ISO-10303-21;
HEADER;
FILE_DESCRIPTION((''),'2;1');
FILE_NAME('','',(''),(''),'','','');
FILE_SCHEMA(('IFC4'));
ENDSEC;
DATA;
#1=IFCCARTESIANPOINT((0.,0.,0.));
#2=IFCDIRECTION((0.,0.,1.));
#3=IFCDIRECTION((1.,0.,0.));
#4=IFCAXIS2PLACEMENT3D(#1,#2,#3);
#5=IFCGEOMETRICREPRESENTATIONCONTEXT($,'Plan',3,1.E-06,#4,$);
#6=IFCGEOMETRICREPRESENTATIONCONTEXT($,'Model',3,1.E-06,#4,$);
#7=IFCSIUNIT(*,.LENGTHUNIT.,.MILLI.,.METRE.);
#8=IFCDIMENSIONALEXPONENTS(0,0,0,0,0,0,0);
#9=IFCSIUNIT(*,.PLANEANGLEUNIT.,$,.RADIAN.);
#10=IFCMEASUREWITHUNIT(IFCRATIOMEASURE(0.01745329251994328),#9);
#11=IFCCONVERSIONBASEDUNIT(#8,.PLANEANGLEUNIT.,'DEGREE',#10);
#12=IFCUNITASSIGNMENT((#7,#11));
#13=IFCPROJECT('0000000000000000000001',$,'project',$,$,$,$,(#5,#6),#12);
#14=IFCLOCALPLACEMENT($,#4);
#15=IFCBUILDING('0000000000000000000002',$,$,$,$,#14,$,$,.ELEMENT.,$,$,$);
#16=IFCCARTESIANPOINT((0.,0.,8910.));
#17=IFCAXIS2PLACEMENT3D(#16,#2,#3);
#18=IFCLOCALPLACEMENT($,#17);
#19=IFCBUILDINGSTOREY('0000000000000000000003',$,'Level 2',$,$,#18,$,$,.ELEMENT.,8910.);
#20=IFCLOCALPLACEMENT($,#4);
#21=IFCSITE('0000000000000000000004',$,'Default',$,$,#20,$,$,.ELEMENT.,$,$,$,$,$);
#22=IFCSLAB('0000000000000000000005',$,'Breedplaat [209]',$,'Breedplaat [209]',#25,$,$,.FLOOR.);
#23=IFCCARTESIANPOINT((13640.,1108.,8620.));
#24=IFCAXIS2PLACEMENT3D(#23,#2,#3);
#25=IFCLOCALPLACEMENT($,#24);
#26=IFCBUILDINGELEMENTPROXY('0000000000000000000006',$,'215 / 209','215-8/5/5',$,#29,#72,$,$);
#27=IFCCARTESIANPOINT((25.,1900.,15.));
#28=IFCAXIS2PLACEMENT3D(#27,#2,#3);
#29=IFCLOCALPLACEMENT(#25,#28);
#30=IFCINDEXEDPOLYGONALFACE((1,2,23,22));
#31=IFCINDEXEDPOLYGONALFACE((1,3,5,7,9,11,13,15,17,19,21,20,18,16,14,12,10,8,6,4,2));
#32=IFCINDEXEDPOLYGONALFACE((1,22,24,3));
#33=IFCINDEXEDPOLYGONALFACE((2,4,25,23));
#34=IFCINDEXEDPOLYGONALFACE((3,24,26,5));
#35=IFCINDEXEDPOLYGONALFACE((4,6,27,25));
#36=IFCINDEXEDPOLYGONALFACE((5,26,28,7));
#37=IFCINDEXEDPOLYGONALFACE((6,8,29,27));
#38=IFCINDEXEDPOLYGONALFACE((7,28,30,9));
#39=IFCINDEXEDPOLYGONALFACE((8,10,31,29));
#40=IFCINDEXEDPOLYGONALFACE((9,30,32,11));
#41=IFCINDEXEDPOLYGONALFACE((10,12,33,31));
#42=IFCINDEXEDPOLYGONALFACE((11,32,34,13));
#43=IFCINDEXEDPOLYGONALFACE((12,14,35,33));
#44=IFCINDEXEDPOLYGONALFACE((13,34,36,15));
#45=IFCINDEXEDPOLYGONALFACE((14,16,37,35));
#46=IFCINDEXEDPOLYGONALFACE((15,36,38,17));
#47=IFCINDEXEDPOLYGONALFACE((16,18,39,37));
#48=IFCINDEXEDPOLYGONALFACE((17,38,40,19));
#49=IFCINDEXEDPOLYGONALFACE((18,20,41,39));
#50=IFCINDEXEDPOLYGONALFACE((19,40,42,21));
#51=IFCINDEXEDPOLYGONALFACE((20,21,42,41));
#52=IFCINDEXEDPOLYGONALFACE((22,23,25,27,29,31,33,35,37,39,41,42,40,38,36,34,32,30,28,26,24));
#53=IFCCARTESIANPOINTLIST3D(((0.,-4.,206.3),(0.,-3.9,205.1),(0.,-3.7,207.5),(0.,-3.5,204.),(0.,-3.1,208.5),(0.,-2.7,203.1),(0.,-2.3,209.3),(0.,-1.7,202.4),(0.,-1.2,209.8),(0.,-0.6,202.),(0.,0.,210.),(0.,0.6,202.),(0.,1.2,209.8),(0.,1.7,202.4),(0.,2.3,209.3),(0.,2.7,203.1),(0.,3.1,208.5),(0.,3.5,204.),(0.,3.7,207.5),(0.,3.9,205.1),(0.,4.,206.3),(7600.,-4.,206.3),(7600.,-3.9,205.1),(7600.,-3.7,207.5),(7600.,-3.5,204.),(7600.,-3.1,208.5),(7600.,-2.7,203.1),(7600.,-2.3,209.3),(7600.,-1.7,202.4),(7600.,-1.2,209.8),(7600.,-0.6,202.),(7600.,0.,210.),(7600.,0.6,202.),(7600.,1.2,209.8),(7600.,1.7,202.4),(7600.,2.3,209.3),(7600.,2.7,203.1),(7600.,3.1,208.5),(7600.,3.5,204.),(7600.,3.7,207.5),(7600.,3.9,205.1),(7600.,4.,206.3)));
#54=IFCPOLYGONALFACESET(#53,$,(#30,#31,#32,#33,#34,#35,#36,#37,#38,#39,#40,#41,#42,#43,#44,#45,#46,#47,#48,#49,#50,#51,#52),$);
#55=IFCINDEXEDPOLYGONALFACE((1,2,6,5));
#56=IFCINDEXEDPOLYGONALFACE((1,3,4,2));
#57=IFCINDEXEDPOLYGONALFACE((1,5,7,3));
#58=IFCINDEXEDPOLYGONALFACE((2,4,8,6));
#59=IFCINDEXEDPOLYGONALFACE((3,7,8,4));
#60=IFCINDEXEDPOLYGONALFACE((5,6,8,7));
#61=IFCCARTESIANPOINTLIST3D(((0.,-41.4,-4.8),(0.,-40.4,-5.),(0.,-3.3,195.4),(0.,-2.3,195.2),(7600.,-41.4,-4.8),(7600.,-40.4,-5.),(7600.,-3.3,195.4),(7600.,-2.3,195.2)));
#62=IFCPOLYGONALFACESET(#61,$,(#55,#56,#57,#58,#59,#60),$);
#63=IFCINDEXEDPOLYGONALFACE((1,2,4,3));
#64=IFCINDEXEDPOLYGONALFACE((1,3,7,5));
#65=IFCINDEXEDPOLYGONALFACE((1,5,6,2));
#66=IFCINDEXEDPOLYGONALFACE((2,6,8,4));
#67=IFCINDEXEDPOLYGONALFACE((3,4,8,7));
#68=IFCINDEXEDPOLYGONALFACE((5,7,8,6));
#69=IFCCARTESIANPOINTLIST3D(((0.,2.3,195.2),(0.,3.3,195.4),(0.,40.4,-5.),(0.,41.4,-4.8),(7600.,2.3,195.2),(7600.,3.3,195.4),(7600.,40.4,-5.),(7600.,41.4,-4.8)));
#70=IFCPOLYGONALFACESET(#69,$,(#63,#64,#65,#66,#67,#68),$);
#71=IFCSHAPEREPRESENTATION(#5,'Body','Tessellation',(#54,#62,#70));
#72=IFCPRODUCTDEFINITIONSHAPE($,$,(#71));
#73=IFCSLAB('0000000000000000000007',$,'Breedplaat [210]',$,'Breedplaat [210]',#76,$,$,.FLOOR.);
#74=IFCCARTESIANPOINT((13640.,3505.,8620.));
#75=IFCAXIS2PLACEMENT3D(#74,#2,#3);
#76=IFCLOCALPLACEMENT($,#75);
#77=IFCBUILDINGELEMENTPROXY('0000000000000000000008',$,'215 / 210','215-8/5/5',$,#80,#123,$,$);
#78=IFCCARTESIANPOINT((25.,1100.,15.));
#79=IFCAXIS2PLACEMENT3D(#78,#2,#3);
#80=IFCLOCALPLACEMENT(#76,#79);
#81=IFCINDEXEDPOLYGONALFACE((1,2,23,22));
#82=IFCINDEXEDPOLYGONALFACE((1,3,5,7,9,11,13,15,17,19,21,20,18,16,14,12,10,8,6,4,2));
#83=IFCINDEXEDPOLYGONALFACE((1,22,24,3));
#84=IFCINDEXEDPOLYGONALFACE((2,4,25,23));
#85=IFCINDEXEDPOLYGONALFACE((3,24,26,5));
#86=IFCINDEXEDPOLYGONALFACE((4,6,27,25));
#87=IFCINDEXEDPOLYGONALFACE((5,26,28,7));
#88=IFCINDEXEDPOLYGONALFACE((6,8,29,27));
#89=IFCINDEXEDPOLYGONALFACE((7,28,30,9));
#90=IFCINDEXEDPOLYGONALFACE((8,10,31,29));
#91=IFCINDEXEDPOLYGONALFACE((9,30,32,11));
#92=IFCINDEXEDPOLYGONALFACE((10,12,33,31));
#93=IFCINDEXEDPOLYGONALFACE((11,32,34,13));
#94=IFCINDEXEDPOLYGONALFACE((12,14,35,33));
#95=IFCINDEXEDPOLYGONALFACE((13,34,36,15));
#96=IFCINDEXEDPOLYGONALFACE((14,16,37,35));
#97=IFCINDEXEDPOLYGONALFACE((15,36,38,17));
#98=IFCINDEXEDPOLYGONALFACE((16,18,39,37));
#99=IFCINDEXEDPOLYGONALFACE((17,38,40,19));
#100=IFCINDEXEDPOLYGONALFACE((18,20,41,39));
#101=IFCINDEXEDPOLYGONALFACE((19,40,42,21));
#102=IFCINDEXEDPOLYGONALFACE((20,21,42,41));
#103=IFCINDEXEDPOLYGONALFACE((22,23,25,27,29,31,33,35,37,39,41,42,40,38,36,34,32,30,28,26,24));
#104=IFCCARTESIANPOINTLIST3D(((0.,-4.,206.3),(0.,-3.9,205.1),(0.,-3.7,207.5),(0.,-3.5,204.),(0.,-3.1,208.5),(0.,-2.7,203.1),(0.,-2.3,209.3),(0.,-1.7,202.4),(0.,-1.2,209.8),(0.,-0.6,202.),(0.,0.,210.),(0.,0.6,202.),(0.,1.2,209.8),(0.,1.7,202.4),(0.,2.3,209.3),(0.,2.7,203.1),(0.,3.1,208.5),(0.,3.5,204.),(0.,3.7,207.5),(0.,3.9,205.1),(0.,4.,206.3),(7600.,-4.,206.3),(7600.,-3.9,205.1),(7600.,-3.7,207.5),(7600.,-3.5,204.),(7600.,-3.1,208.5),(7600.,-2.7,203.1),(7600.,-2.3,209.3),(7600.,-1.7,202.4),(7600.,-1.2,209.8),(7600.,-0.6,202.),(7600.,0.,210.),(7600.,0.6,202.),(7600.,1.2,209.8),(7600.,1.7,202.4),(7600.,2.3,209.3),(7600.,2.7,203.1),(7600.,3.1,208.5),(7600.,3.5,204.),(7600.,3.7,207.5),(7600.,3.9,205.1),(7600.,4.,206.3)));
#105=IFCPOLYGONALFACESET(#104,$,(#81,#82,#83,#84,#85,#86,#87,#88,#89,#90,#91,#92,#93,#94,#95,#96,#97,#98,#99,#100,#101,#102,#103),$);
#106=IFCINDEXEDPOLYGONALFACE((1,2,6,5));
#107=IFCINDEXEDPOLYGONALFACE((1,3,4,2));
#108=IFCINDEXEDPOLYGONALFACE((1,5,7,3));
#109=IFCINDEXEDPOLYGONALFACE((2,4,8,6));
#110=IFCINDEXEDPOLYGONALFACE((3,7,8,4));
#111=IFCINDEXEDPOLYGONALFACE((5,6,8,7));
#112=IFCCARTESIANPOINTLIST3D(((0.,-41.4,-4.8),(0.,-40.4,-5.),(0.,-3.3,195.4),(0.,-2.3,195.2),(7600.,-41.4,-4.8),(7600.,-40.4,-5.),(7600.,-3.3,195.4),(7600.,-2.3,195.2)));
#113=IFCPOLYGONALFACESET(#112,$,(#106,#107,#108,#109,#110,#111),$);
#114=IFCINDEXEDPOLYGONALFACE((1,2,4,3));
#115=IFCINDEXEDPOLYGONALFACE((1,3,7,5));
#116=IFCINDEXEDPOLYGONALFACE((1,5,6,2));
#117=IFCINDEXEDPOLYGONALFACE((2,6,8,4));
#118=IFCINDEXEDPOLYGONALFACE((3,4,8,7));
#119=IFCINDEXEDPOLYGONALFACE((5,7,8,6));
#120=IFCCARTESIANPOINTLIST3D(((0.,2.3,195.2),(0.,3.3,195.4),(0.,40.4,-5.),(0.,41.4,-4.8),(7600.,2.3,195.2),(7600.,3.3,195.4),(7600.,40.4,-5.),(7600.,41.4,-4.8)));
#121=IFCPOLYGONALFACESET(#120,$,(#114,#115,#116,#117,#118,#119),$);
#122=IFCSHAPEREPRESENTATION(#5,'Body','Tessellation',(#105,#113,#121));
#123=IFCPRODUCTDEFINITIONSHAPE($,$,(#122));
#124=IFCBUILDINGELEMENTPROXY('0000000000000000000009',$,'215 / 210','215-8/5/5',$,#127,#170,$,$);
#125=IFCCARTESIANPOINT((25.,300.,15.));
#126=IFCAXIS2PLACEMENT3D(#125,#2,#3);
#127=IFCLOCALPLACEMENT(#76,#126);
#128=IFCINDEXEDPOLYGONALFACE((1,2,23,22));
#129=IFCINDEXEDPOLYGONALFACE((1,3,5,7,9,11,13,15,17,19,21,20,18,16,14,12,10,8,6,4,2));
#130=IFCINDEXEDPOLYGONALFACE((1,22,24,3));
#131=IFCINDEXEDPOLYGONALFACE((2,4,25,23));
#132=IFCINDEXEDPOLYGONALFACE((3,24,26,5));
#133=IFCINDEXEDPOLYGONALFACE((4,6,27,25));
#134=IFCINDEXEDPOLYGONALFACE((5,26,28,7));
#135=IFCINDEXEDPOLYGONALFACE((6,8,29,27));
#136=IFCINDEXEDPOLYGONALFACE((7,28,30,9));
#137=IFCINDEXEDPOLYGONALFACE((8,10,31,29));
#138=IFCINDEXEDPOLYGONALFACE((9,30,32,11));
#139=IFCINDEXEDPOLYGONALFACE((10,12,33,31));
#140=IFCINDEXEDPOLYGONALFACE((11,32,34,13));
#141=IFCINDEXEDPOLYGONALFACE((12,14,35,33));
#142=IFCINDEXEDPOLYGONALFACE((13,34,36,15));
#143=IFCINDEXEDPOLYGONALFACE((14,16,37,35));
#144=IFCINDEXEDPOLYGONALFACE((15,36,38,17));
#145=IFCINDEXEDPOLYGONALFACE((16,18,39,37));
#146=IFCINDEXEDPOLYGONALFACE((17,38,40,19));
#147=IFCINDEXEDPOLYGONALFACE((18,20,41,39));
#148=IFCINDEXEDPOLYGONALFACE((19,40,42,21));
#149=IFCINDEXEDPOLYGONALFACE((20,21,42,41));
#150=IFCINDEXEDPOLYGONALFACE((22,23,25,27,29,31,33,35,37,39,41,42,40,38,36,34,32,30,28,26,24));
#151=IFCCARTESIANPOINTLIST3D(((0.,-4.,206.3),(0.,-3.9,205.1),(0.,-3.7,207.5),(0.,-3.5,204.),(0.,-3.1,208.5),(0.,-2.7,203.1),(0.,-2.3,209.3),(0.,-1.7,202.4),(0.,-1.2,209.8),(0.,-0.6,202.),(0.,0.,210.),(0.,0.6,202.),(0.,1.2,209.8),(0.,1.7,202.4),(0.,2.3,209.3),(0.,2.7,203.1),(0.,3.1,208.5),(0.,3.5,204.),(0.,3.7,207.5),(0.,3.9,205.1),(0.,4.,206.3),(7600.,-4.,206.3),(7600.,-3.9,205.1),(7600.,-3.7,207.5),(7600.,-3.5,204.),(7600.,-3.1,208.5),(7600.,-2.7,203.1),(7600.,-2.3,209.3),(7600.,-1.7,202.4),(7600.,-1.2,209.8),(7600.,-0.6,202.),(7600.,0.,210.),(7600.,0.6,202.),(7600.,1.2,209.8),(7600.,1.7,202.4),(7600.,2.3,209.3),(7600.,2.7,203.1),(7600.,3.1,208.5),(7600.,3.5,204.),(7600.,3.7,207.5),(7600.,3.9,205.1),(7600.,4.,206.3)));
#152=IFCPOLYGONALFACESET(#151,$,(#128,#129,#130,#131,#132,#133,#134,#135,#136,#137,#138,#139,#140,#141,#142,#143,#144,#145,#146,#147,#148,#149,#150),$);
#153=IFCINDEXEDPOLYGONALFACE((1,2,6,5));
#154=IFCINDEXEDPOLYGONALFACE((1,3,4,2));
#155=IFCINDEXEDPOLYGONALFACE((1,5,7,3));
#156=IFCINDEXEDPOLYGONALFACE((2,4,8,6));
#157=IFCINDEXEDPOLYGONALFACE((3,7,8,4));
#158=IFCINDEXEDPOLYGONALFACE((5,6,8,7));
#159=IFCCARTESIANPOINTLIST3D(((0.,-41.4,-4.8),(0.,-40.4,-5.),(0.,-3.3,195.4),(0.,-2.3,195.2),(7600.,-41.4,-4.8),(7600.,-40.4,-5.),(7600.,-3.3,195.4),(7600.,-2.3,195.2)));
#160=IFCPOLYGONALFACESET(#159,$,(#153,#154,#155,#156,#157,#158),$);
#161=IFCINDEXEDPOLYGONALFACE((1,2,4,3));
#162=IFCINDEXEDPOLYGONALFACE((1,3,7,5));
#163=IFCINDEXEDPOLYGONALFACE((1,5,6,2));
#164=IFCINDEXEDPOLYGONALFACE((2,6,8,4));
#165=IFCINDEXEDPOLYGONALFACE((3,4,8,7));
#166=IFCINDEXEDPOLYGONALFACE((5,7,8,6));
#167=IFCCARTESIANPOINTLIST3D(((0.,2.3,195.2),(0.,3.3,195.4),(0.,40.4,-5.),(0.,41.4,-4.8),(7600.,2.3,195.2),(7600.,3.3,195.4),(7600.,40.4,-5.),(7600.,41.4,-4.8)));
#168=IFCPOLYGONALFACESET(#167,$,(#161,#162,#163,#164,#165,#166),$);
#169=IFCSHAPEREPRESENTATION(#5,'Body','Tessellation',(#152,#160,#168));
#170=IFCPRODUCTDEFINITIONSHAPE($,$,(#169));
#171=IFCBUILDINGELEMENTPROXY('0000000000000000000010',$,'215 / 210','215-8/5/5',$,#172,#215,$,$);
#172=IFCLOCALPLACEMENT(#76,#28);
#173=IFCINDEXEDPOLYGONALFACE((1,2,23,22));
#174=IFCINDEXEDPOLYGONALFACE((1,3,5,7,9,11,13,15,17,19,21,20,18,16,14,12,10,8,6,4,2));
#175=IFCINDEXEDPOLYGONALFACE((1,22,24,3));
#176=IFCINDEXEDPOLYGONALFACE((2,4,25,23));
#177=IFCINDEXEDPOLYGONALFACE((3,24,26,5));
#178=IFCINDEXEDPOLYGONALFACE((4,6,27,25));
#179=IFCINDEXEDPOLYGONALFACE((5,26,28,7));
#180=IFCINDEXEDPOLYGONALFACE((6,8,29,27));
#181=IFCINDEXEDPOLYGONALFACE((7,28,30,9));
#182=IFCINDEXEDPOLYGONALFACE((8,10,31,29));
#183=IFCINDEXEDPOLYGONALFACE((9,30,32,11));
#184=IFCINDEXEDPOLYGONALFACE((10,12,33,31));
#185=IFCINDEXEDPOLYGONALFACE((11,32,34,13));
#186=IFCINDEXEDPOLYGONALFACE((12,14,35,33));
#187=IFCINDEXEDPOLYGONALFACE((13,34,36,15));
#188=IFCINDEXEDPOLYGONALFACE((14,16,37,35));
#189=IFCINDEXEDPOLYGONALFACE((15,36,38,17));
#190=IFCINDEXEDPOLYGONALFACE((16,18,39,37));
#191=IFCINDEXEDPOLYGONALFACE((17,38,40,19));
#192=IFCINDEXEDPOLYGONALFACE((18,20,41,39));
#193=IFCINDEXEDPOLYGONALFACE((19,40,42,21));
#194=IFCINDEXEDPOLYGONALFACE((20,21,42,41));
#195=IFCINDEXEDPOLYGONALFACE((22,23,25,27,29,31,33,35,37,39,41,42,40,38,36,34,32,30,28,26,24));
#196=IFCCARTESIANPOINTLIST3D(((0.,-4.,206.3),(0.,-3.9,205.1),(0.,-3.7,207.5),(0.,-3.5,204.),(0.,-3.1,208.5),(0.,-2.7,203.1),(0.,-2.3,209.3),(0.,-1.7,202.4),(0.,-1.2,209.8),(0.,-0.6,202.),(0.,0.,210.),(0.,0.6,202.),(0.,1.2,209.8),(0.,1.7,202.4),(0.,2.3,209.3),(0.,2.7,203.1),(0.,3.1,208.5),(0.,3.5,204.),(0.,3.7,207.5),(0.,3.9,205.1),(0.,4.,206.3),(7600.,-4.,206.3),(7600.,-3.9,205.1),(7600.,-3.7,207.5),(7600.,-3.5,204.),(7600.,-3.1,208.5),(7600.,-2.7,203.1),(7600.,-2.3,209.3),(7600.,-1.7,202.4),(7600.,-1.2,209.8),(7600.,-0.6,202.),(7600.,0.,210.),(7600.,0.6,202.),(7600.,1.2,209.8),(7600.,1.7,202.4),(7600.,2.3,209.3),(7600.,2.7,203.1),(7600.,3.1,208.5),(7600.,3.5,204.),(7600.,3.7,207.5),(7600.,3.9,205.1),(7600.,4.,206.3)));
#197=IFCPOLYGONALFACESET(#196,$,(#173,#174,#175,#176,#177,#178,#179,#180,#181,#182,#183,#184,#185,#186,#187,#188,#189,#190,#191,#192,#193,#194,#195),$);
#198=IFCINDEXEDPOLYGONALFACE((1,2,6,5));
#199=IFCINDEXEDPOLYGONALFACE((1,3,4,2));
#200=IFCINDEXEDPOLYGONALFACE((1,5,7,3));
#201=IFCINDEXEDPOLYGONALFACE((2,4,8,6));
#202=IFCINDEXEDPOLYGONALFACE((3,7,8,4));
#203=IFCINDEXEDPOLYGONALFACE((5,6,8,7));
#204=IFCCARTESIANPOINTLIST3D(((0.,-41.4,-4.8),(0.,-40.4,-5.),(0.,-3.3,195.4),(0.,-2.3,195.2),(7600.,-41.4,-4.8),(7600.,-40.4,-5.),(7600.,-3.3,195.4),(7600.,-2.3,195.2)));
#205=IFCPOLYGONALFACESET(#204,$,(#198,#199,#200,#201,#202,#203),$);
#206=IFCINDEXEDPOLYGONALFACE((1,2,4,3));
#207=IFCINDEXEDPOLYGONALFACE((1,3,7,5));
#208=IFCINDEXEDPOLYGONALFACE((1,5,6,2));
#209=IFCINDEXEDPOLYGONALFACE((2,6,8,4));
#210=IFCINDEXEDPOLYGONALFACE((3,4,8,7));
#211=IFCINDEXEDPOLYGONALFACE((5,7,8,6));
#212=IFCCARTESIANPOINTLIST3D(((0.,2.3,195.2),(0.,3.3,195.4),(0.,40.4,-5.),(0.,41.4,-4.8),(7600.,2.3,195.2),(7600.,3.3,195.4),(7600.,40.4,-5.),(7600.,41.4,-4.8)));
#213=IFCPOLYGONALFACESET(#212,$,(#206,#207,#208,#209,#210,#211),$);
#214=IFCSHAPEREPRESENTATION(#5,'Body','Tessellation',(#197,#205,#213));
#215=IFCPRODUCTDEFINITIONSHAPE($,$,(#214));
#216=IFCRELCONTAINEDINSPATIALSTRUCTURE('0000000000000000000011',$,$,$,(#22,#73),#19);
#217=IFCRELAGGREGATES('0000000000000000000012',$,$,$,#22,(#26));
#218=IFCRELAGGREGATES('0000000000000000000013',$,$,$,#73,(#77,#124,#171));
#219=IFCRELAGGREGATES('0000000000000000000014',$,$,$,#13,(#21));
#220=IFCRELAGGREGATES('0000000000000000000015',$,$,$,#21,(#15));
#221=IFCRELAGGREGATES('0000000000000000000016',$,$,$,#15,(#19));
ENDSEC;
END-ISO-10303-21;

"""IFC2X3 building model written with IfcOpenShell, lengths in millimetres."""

from ifc_helpers import new_model, entity, si_unit, converted_unit, frame, origin_with_axes, origin_2d_with_axis, place, context, project, spatial, rectangle, circle, extrude, element, aggregate, save


model = new_model("IFC2X3")

# Units and contexts
plan_context = context("Plan", 3, precision=1e-06, world=origin_with_axes())
model_context = context("Model", 3, precision=1e-06, world=origin_with_axes())
ifc_project = project(units=[si_unit("LENGTHUNIT", "METRE", prefix="MILLI"), converted_unit("PLANEANGLEUNIT", "DEGREE", entity("IfcRatioMeasure", 0.01745329251994328), si_unit("PLANEANGLEUNIT", "RADIAN"), dimensions=[0, 0, 0, 0, 0, 0, 0])], contexts=[plan_context, model_context])

# Site, building, storey
site_placement = place(None, origin_with_axes())
site = spatial("IfcSite", under=ifc_project, at=site_placement, Name="Default", CompositionType="ELEMENT")
building_placement = place(None, origin_with_axes())
building = spatial("IfcBuilding", under=site, at=building_placement, CompositionType="ELEMENT")
storey_placement = place(None, frame((0.0, 0.0, 8910.0), z_axis=(0.0, 0.0, 1.0), x_axis=(1.0, 0.0, 0.0)))
storey = spatial("IfcBuildingStorey", under=building, at=storey_placement, Name="Level 2", CompositionType="ELEMENT", Elevation=8910.0)

# Slabs, building element proxies
slab_1_placement = place(None, frame((13640.0, 1108.0, 8620.0), z_axis=(0.0, 0.0, 1.0), x_axis=(1.0, 0.0, 0.0)))
slab_1 = element("IfcSlab", 1, at=slab_1_placement, inside=storey, Name="Breedplaat [209]", ObjectType="Breedplaat [209]", PredefinedType="FLOOR")
proxy_1_placement = place(slab_1_placement, frame((25.0, 1900.0, 15.0), z_axis=(0.0, 0.0, 1.0), x_axis=(1.0, 0.0, 0.0)))
proxy_1 = element("IfcBuildingElementProxy", 2, at=proxy_1_placement, Name="215 / 209", Description="215-8/5/5", context=plan_context, shape_type="SweptSolid", body=[
    extrude(circle(Radius=4.0, at=origin_2d_with_axis()), frame((0.0, 0.0, 206.0), z_axis=(1.0, 0.0, 0.0), x_axis=(0.0, 0.0, 1.0)), (0.0, 0.0, 1.0), 7600.0),
    extrude(rectangle(XDim=203.8, YDim=1.0, at=origin_2d_with_axis()), frame((0.0, -21.9, 95.2), z_axis=(1.0, 0.0, 0.0), x_axis=(0.0, 0.187112, 0.982339)), (0.0, 0.0, 1.0), 7600.0),
    extrude(rectangle(XDim=203.8, YDim=1.0, at=origin_2d_with_axis()), frame((0.0, 21.9, 95.2), z_axis=(1.0, 0.0, 0.0), x_axis=(0.0, -0.187112, 0.982339)), (0.0, 0.0, 1.0), 7600.0),
])
aggregate(slab_1, [proxy_1])
slab_2_placement = place(None, frame((13640.0, 3505.0, 8620.0), z_axis=(0.0, 0.0, 1.0), x_axis=(1.0, 0.0, 0.0)))
slab_2 = element("IfcSlab", 3, at=slab_2_placement, inside=storey, Name="Breedplaat [210]", ObjectType="Breedplaat [210]", PredefinedType="FLOOR")
proxy_2_placement = place(slab_2_placement, frame((25.0, 1100.0, 15.0), z_axis=(0.0, 0.0, 1.0), x_axis=(1.0, 0.0, 0.0)))
proxy_2 = element("IfcBuildingElementProxy", 4, at=proxy_2_placement, Name="215 / 210", Description="215-8/5/5", context=plan_context, shape_type="SweptSolid", body=[
    extrude(circle(Radius=4.0, at=origin_2d_with_axis()), frame((0.0, 0.0, 206.0), z_axis=(1.0, 0.0, 0.0), x_axis=(0.0, 0.0, 1.0)), (0.0, 0.0, 1.0), 7600.0),
    extrude(rectangle(XDim=203.8, YDim=1.0, at=origin_2d_with_axis()), frame((0.0, -21.9, 95.2), z_axis=(1.0, 0.0, 0.0), x_axis=(0.0, 0.187112, 0.982339)), (0.0, 0.0, 1.0), 7600.0),
    extrude(rectangle(XDim=203.8, YDim=1.0, at=origin_2d_with_axis()), frame((0.0, 21.9, 95.2), z_axis=(1.0, 0.0, 0.0), x_axis=(0.0, -0.187112, 0.982339)), (0.0, 0.0, 1.0), 7600.0),
])
proxy_3_placement = place(slab_2_placement, frame((25.0, 300.0, 15.0), z_axis=(0.0, 0.0, 1.0), x_axis=(1.0, 0.0, 0.0)))
proxy_3 = element("IfcBuildingElementProxy", 5, at=proxy_3_placement, Name="215 / 210", Description="215-8/5/5", context=plan_context, shape_type="SweptSolid", body=[
    extrude(circle(Radius=4.0, at=origin_2d_with_axis()), frame((0.0, 0.0, 206.0), z_axis=(1.0, 0.0, 0.0), x_axis=(0.0, 0.0, 1.0)), (0.0, 0.0, 1.0), 7600.0),
    extrude(rectangle(XDim=203.8, YDim=1.0, at=origin_2d_with_axis()), frame((0.0, -21.9, 95.2), z_axis=(1.0, 0.0, 0.0), x_axis=(0.0, 0.187112, 0.982339)), (0.0, 0.0, 1.0), 7600.0),
    extrude(rectangle(XDim=203.8, YDim=1.0, at=origin_2d_with_axis()), frame((0.0, 21.9, 95.2), z_axis=(1.0, 0.0, 0.0), x_axis=(0.0, -0.187112, 0.982339)), (0.0, 0.0, 1.0), 7600.0),
])
proxy_4_placement = place(slab_2_placement, frame((25.0, 1900.0, 15.0), z_axis=(0.0, 0.0, 1.0), x_axis=(1.0, 0.0, 0.0)))
proxy_4 = element("IfcBuildingElementProxy", 6, at=proxy_4_placement, Name="215 / 210", Description="215-8/5/5", context=plan_context, shape_type="SweptSolid", body=[
    extrude(circle(Radius=4.0, at=origin_2d_with_axis()), frame((0.0, 0.0, 206.0), z_axis=(1.0, 0.0, 0.0), x_axis=(0.0, 0.0, 1.0)), (0.0, 0.0, 1.0), 7600.0),
    extrude(rectangle(XDim=203.8, YDim=1.0, at=origin_2d_with_axis()), frame((0.0, -21.9, 95.2), z_axis=(1.0, 0.0, 0.0), x_axis=(0.0, 0.187112, 0.982339)), (0.0, 0.0, 1.0), 7600.0),
    extrude(rectangle(XDim=203.8, YDim=1.0, at=origin_2d_with_axis()), frame((0.0, 21.9, 95.2), z_axis=(1.0, 0.0, 0.0), x_axis=(0.0, -0.187112, 0.982339)), (0.0, 0.0, 1.0), 7600.0),
])
aggregate(slab_2, [proxy_2, proxy_3, proxy_4])

save(model, "model.ifc")
